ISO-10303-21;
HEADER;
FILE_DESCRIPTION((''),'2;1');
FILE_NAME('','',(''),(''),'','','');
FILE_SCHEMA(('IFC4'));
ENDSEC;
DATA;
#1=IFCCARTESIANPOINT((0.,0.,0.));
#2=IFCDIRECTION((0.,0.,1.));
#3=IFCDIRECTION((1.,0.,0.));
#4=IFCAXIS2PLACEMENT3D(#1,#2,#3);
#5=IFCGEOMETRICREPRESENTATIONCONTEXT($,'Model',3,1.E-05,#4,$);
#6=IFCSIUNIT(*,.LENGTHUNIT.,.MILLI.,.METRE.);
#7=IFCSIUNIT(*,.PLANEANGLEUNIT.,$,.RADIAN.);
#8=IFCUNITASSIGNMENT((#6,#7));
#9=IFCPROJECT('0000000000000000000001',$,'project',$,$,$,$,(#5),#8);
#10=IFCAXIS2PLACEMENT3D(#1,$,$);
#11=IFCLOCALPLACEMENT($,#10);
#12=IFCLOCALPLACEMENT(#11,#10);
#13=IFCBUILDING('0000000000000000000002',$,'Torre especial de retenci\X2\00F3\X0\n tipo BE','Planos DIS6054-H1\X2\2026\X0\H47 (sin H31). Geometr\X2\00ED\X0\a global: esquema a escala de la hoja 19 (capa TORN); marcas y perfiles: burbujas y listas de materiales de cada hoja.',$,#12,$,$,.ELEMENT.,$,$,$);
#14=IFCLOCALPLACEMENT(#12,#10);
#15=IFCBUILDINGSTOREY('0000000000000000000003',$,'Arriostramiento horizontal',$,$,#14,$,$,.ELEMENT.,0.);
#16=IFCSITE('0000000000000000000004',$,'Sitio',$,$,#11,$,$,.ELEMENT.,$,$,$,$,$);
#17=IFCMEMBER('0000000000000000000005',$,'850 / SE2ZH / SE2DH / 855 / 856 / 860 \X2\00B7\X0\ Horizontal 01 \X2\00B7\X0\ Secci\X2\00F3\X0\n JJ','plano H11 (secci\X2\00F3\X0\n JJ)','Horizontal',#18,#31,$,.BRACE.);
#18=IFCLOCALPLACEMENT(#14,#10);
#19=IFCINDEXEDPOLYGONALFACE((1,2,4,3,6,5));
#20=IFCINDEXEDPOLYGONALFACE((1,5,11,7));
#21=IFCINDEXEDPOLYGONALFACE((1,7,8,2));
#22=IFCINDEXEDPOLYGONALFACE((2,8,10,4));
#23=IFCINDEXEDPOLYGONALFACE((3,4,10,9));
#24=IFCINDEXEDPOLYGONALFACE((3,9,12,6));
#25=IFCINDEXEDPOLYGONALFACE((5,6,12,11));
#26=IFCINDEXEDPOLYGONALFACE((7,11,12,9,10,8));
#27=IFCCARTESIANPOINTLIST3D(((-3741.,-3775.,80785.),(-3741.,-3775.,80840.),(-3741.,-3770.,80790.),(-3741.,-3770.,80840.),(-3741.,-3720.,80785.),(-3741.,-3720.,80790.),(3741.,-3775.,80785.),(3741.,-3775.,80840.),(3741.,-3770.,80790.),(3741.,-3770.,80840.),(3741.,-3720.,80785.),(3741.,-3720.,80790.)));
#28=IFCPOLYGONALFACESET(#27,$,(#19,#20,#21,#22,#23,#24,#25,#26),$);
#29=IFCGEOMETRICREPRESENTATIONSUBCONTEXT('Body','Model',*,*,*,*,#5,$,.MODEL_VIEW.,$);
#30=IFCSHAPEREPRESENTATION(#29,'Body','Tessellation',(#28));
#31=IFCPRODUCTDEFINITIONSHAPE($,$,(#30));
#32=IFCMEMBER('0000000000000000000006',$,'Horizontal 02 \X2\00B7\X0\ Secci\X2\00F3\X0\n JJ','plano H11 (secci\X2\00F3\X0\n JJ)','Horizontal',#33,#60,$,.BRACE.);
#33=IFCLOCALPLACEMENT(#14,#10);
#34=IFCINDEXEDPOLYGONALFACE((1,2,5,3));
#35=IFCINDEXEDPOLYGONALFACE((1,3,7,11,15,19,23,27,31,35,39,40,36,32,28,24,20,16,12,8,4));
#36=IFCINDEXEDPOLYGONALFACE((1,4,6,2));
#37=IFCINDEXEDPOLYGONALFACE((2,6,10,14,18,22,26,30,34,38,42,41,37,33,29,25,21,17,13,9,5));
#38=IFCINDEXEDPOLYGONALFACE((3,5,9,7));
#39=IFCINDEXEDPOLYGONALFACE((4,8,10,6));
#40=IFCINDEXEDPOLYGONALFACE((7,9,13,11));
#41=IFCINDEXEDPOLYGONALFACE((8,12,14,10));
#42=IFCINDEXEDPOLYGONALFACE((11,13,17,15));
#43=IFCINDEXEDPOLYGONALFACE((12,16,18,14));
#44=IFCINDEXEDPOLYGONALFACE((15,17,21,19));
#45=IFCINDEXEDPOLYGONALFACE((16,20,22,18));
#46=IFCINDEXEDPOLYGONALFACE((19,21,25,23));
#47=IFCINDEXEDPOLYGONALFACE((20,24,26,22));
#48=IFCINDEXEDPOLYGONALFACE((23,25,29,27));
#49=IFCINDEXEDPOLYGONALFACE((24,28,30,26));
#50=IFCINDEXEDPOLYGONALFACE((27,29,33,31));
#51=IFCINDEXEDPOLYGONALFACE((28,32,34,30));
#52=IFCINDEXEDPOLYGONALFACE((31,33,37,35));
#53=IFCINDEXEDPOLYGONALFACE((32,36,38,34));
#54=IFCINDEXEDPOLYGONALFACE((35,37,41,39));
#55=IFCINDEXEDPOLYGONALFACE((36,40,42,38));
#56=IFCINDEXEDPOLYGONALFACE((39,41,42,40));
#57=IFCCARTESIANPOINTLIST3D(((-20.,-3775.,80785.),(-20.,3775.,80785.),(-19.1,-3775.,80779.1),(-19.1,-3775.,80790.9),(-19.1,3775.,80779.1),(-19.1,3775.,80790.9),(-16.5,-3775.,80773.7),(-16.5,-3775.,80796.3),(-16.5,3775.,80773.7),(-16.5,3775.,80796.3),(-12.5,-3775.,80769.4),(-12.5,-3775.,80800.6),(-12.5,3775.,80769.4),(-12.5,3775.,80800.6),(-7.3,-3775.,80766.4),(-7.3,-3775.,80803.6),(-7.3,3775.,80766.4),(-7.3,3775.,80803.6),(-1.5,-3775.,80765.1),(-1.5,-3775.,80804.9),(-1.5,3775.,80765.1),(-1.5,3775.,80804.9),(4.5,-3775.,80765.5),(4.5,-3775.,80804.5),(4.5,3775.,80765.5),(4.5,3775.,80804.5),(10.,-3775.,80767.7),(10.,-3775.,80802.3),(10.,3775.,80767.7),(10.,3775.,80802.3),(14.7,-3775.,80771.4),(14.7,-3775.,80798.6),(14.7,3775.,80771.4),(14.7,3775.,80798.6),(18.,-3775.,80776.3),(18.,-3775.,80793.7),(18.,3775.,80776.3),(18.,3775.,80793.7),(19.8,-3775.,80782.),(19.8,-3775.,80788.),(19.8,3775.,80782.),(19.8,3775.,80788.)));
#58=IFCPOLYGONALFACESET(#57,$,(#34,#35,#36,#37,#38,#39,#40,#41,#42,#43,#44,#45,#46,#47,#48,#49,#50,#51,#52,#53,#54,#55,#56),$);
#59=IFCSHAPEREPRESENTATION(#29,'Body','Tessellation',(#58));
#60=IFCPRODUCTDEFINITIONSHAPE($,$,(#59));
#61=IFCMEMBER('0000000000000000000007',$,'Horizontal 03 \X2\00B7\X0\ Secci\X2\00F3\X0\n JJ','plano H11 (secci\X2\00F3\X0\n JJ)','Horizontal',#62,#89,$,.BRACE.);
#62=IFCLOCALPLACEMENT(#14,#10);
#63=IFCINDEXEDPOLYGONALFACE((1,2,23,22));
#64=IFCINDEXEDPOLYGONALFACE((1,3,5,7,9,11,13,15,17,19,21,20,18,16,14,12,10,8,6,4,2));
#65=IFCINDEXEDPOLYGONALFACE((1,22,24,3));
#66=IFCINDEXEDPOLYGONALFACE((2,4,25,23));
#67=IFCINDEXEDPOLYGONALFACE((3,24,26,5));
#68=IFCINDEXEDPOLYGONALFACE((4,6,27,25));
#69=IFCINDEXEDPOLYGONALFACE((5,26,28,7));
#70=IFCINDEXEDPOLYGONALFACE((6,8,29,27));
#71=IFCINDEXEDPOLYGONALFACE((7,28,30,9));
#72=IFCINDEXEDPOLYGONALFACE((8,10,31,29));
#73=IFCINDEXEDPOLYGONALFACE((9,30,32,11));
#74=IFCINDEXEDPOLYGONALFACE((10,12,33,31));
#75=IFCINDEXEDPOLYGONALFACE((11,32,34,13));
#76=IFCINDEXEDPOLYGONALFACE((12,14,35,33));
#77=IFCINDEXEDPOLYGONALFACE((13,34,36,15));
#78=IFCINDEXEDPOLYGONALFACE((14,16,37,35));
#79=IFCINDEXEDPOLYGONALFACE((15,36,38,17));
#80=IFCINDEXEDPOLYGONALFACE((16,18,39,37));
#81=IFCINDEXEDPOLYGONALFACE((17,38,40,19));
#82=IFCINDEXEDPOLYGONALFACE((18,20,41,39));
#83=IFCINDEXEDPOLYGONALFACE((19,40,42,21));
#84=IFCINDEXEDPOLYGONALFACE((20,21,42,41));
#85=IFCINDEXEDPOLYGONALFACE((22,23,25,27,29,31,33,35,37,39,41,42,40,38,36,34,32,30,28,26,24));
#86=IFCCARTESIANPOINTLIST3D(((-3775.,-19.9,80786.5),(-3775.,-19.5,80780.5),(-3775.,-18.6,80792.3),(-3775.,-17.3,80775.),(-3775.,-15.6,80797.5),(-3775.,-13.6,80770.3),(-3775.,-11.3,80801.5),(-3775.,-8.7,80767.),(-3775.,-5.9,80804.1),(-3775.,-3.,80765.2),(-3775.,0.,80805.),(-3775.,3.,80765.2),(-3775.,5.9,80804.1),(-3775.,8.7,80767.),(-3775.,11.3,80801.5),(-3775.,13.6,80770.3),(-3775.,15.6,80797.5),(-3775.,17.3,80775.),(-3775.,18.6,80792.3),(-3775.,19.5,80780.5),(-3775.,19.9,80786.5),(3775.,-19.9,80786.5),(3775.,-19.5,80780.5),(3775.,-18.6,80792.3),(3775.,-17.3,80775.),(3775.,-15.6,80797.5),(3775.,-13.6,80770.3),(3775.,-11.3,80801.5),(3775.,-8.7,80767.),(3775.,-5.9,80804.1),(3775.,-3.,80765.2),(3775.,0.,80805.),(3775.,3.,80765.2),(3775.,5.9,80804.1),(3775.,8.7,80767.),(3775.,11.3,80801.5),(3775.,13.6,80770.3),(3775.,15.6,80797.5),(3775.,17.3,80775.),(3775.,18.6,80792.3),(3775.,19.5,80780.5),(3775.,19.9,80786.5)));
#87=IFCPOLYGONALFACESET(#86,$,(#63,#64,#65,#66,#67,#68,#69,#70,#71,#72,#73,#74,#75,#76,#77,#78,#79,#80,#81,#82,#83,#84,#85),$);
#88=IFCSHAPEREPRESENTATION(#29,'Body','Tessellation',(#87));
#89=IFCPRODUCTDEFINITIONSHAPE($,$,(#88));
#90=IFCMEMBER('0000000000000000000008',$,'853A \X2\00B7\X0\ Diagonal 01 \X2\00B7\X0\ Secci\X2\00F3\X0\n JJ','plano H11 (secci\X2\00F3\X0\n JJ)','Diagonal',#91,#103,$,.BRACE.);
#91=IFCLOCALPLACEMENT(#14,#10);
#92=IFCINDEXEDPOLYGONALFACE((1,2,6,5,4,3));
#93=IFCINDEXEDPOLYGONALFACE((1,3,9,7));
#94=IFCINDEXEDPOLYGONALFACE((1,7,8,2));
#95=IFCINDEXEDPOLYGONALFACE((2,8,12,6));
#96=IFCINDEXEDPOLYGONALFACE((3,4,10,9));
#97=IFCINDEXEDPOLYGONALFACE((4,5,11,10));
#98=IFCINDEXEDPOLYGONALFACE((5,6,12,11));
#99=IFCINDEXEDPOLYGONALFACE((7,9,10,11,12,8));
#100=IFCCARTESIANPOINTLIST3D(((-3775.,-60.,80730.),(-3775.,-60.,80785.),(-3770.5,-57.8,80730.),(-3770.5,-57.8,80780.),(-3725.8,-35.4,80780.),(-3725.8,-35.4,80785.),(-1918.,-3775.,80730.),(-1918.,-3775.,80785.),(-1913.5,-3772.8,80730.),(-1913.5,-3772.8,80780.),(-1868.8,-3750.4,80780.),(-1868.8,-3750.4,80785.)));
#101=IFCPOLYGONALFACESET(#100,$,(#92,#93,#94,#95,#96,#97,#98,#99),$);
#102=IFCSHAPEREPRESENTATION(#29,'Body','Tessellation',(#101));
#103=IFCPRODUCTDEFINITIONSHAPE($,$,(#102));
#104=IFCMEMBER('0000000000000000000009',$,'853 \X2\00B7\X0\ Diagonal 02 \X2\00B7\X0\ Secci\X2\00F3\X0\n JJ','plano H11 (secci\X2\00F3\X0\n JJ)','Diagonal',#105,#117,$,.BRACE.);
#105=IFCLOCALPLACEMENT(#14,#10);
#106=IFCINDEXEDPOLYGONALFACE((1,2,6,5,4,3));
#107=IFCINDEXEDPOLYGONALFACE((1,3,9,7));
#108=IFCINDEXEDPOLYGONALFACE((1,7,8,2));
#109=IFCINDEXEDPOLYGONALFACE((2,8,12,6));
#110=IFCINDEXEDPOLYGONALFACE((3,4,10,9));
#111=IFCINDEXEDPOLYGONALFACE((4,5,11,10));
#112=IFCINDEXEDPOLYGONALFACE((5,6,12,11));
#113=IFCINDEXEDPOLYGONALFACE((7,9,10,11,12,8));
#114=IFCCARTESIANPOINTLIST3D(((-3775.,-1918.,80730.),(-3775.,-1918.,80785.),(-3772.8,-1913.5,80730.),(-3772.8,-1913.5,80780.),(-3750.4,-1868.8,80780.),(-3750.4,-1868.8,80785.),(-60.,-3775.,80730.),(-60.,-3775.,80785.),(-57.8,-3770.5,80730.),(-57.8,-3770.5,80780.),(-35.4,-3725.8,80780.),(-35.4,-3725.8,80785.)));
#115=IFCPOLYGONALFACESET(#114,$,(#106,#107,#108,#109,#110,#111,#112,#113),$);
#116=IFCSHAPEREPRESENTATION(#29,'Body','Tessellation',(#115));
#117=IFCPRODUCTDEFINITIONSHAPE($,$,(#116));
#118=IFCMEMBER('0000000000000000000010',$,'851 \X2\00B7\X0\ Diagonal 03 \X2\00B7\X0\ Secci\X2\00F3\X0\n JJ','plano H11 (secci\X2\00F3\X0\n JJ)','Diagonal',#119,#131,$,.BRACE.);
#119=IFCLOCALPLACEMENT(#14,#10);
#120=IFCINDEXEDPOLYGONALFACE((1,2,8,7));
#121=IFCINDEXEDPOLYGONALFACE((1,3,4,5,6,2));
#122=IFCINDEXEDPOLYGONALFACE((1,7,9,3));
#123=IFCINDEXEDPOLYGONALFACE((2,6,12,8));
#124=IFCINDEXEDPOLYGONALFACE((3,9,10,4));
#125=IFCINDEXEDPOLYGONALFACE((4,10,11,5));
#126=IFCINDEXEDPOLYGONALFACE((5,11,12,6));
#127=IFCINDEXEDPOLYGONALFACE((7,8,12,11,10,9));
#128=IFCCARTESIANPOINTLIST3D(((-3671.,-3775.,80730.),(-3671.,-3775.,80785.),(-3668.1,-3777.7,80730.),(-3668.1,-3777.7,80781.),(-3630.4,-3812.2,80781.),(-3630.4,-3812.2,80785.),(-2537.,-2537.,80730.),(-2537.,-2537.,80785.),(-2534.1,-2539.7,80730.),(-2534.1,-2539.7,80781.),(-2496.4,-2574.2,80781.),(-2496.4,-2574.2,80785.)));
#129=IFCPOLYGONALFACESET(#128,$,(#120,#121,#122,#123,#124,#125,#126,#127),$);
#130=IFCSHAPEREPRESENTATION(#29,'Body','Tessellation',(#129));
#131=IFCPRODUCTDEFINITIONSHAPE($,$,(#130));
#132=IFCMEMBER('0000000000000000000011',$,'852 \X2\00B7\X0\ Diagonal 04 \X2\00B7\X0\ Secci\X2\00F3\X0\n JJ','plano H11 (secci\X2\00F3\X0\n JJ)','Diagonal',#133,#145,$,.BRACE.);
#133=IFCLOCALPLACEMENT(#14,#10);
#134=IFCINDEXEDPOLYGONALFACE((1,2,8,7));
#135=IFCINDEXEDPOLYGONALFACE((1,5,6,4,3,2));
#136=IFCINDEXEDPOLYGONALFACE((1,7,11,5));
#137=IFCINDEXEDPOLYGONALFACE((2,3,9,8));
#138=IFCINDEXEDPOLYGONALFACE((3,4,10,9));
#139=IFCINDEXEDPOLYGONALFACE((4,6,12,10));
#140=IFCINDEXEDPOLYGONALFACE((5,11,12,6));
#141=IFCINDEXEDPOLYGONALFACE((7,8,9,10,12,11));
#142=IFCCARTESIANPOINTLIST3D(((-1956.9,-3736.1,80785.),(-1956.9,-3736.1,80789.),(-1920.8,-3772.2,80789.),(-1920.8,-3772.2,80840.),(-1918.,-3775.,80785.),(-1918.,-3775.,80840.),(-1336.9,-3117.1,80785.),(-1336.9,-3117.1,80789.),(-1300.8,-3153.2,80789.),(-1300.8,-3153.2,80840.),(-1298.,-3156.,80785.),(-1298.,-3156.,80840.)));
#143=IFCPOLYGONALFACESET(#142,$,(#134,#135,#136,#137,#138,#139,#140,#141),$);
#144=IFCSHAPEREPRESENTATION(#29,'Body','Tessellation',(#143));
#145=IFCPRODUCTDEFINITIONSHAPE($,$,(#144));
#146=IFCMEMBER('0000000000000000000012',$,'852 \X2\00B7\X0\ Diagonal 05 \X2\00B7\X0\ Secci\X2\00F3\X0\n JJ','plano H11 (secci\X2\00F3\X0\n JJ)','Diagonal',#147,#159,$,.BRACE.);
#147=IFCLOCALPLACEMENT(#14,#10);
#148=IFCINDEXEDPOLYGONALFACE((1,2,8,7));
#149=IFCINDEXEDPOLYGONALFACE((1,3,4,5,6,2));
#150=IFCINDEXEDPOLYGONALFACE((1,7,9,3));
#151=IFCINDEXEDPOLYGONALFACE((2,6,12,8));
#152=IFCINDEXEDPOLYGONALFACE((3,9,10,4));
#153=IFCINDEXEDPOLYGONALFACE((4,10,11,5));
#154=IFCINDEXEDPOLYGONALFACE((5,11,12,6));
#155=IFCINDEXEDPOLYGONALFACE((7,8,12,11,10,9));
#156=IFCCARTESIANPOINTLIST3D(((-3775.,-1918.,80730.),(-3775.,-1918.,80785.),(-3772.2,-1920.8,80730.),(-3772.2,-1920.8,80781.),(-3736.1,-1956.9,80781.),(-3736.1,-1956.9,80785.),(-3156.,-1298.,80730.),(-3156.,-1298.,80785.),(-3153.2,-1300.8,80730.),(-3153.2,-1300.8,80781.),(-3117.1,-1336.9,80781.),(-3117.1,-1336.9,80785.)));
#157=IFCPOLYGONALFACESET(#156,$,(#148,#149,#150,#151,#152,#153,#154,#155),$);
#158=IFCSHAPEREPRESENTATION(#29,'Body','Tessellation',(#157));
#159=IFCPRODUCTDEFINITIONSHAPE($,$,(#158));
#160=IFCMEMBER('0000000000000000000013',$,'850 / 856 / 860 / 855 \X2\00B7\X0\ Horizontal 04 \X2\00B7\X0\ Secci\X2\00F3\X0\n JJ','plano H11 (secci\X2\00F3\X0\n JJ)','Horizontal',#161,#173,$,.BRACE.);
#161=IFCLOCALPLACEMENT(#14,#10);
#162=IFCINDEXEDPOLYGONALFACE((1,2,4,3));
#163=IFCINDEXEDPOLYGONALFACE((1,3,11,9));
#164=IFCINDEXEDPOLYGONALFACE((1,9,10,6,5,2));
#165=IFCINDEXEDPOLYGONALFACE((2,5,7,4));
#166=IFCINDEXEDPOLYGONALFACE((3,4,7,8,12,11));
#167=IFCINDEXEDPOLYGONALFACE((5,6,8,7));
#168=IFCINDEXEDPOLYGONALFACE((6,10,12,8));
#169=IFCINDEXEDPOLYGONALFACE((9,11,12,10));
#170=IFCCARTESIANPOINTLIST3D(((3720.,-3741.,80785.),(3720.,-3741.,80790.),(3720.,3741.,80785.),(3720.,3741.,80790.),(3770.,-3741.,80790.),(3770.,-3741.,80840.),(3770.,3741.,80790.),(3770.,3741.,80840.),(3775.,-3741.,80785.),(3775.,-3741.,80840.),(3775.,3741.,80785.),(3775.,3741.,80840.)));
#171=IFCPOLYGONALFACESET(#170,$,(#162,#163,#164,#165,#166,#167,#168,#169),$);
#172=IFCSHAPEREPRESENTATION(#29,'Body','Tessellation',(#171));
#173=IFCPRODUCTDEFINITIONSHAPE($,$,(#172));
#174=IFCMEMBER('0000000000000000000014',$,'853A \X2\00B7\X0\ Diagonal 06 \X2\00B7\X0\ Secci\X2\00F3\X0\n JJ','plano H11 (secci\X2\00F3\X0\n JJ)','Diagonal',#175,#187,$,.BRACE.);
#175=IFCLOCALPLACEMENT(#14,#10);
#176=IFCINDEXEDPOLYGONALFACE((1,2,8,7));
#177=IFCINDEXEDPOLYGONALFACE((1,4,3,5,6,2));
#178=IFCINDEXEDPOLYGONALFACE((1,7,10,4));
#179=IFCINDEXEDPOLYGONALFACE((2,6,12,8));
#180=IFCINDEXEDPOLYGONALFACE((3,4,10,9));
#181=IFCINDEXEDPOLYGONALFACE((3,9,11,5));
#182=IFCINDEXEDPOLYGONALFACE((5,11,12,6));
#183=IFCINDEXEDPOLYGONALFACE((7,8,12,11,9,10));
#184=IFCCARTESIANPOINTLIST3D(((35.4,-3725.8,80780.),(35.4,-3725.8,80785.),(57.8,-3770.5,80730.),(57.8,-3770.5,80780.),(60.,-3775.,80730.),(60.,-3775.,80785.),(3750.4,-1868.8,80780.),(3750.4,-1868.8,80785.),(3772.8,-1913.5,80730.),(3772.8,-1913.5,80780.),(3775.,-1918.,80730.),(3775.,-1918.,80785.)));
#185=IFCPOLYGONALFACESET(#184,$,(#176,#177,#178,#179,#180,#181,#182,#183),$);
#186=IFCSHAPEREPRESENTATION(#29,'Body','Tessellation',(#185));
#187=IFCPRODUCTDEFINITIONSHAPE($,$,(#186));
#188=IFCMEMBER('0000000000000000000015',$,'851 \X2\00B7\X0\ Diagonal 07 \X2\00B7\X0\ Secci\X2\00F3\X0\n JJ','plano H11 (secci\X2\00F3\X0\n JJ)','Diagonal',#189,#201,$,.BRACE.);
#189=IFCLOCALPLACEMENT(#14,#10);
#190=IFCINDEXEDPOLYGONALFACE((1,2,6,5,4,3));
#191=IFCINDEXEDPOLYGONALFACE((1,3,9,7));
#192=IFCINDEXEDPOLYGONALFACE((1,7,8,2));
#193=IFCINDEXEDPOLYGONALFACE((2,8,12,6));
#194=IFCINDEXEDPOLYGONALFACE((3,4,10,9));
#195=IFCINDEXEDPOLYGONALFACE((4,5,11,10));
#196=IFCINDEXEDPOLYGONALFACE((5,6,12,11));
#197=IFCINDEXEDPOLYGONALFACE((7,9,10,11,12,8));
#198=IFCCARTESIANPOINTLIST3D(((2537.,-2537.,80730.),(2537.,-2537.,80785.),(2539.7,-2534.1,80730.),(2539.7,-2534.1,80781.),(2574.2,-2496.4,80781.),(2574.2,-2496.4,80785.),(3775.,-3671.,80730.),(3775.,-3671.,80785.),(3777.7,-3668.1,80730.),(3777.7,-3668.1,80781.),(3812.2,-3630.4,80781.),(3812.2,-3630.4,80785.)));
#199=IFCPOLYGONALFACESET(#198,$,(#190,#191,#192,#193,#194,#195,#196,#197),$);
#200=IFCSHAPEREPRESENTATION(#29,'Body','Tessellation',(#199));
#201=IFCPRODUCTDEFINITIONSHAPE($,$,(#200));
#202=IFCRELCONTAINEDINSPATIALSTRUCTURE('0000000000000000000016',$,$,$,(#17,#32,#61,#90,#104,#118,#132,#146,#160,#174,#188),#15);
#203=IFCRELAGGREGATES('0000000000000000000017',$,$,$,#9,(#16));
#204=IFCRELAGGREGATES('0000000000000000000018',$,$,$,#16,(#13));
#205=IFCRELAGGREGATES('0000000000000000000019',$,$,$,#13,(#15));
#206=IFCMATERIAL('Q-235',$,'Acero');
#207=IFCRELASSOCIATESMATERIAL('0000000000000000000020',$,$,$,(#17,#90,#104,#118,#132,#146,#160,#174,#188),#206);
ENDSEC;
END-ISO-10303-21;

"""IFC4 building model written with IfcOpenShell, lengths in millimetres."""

from ifc_helpers import new_model, si_unit, frame, frame_2d, origin, origin_with_axes, place, context, subcontext, project, spatial, circle, l_section, extrude, material, element, save


model = new_model("IFC4")

# Units and contexts
model_context = context("Model", 3, precision=1e-05, world=origin_with_axes())
body_context = subcontext(model_context, "Body", "Model", "MODEL_VIEW")
ifc_project = project(units=[si_unit("LENGTHUNIT", "METRE", prefix="MILLI"), si_unit("PLANEANGLEUNIT", "RADIAN")], contexts=[model_context])

# Site, building, storey
site_placement = place(None, origin())
site = spatial("IfcSite", under=ifc_project, at=site_placement, Name="Sitio", CompositionType="ELEMENT")
building_placement = place(site_placement, origin())
building = spatial("IfcBuilding", under=site, at=building_placement, Name="Torre especial de retención tipo BE", Description="Planos DIS6054-H1…H47 (sin H31). Geometría global: esquema a escala de la hoja 19 (capa TORN); marcas y perfiles: burbujas y listas de materiales de cada hoja.", CompositionType="ELEMENT")
storey_placement = place(building_placement, origin())
storey = spatial("IfcBuildingStorey", under=building, at=storey_placement, Name="Arriostramiento horizontal", CompositionType="ELEMENT", Elevation=0.0)

# Members
ifc_material_1 = material(Name="Q-235", Category="Acero")
member_1_placement = place(storey_placement, frame((-3741.0, -3775.0, 80785.0), z_axis=(1.0, 0.0, 0.0), x_axis=(0.0, 1.0, 0.0)))
element("IfcMember", 1, at=member_1_placement, inside=storey, material=ifc_material_1, Name="850 / SE2ZH / SE2DH / 855 / 856 / 860 · Horizontal 01 · Sección JJ", Description="plano H11 (sección JJ)", ObjectType="Horizontal", PredefinedType="BRACE", context=body_context, shape_type="SweptSolid", body=[
    extrude(l_section(Depth=55.0, Width=55.0, Thickness=5.0, at=frame_2d((27.5, 27.5))), None, (0.0, 0.0, 1.0), 7482.0),
])
for number, where, z_axis, x_axis, name in (
    (2, (0.0, -3775.0, 80785.0), (0.0, 1.0, 0.0), (-1.0, 0.0, 0.0), "Horizontal 02 · Sección JJ"),
    (3, (-3775.0, 0.0, 80785.0), (1.0, 0.0, 0.0), (0.0, 0.0, 1.0), "Horizontal 03 · Sección JJ"),
):
    element("IfcMember", number, at=place(storey_placement, frame(where, z_axis=z_axis, x_axis=x_axis)), inside=storey, Name=name, Description="plano H11 (sección JJ)", ObjectType="Horizontal", PredefinedType="BRACE", context=body_context, shape_type="SweptSolid", body=[
        extrude(circle(Radius=20.0), None, (0.0, 0.0, 1.0), 7550.0),
    ])
for number, where, z_axis, x_axis, name in (
    (4, (-1918.0, -3775.0, 80785.0), (-0.447117, 0.894475, 0.0), (0.894475, 0.447117, 0.0), "853A · Diagonal 01 · Sección JJ"),
    (5, (-60.0, -3775.0, 80785.0), (-0.894475, 0.447117, 0.0), (0.447117, 0.894475, 0.0), "853 · Diagonal 02 · Sección JJ"),
):
    element("IfcMember", number, at=place(storey_placement, frame(where, z_axis=z_axis, x_axis=x_axis)), inside=storey, material=ifc_material_1, Name=name, Description="plano H11 (sección JJ)", ObjectType="Diagonal", PredefinedType="BRACE", context=body_context, shape_type="SweptSolid", body=[
        extrude(l_section(Depth=55.0, Width=55.0, Thickness=5.0, at=frame_2d((27.5, 27.5))), None, (0.0, 0.0, 1.0), 4153.3),
    ])
member_2_placement = place(storey_placement, frame((-3671.0, -3775.0, 80785.0), z_axis=(0.675455, 0.737401, 0.0), x_axis=(0.737401, -0.675455, 0.0)))
element("IfcMember", 6, at=member_2_placement, inside=storey, material=ifc_material_1, Name="851 · Diagonal 03 · Sección JJ", Description="plano H11 (sección JJ)", ObjectType="Diagonal", PredefinedType="BRACE", context=body_context, shape_type="SweptSolid", body=[
    extrude(l_section(Depth=55.0, Width=55.0, Thickness=4.0, at=frame_2d((27.5, 27.5))), None, (0.0, 0.0, 1.0), 1678.9),
])
for number, where, z_axis, x_axis, name in (
    (7, (-1918.0, -3775.0, 80785.0), (0.707677, 0.706536, 0.0), (-0.706536, 0.707677, 0.0), "852 · Diagonal 04 · Sección JJ"),
    (8, (-3775.0, -1918.0, 80785.0), (0.706536, 0.707677, 0.0), (0.707677, -0.706536, 0.0), "852 · Diagonal 05 · Sección JJ"),
):
    element("IfcMember", number, at=place(storey_placement, frame(where, z_axis=z_axis, x_axis=x_axis)), inside=storey, material=ifc_material_1, Name=name, Description="plano H11 (sección JJ)", ObjectType="Diagonal", PredefinedType="BRACE", context=body_context, shape_type="SweptSolid", body=[
        extrude(l_section(Depth=55.0, Width=55.0, Thickness=4.0, at=frame_2d((27.5, 27.5))), None, (0.0, 0.0, 1.0), 876.1),
    ])
member_3_placement = place(storey_placement, frame((3775.0, -3741.0, 80785.0), z_axis=(0.0, 1.0, 0.0), x_axis=(-1.0, 0.0, 0.0)))
element("IfcMember", 9, at=member_3_placement, inside=storey, material=ifc_material_1, Name="850 / 856 / 860 / 855 · Horizontal 04 · Sección JJ", Description="plano H11 (sección JJ)", ObjectType="Horizontal", PredefinedType="BRACE", context=body_context, shape_type="SweptSolid", body=[
    extrude(l_section(Depth=55.0, Width=55.0, Thickness=5.0, at=frame_2d((27.5, 27.5))), None, (0.0, 0.0, 1.0), 7482.0),
])
member_4_placement = place(storey_placement, frame((3775.0, -1918.0, 80785.0), z_axis=(-0.894475, -0.447117, 0.0), x_axis=(-0.447117, 0.894475, 0.0)))
element("IfcMember", 10, at=member_4_placement, inside=storey, material=ifc_material_1, Name="853A · Diagonal 06 · Sección JJ", Description="plano H11 (sección JJ)", ObjectType="Diagonal", PredefinedType="BRACE", context=body_context, shape_type="SweptSolid", body=[
    extrude(l_section(Depth=55.0, Width=55.0, Thickness=5.0, at=frame_2d((27.5, 27.5))), None, (0.0, 0.0, 1.0), 4153.3),
])
member_5_placement = place(storey_placement, frame((3775.0, -3671.0, 80785.0), z_axis=(-0.737401, 0.675455, 0.0), x_axis=(0.675455, 0.737401, 0.0)))
element("IfcMember", 11, at=member_5_placement, inside=storey, material=ifc_material_1, Name="851 · Diagonal 07 · Sección JJ", Description="plano H11 (sección JJ)", ObjectType="Diagonal", PredefinedType="BRACE", context=body_context, shape_type="SweptSolid", body=[
    extrude(l_section(Depth=55.0, Width=55.0, Thickness=4.0, at=frame_2d((27.5, 27.5))), None, (0.0, 0.0, 1.0), 1678.9),
])

save(model, "model.ifc")
